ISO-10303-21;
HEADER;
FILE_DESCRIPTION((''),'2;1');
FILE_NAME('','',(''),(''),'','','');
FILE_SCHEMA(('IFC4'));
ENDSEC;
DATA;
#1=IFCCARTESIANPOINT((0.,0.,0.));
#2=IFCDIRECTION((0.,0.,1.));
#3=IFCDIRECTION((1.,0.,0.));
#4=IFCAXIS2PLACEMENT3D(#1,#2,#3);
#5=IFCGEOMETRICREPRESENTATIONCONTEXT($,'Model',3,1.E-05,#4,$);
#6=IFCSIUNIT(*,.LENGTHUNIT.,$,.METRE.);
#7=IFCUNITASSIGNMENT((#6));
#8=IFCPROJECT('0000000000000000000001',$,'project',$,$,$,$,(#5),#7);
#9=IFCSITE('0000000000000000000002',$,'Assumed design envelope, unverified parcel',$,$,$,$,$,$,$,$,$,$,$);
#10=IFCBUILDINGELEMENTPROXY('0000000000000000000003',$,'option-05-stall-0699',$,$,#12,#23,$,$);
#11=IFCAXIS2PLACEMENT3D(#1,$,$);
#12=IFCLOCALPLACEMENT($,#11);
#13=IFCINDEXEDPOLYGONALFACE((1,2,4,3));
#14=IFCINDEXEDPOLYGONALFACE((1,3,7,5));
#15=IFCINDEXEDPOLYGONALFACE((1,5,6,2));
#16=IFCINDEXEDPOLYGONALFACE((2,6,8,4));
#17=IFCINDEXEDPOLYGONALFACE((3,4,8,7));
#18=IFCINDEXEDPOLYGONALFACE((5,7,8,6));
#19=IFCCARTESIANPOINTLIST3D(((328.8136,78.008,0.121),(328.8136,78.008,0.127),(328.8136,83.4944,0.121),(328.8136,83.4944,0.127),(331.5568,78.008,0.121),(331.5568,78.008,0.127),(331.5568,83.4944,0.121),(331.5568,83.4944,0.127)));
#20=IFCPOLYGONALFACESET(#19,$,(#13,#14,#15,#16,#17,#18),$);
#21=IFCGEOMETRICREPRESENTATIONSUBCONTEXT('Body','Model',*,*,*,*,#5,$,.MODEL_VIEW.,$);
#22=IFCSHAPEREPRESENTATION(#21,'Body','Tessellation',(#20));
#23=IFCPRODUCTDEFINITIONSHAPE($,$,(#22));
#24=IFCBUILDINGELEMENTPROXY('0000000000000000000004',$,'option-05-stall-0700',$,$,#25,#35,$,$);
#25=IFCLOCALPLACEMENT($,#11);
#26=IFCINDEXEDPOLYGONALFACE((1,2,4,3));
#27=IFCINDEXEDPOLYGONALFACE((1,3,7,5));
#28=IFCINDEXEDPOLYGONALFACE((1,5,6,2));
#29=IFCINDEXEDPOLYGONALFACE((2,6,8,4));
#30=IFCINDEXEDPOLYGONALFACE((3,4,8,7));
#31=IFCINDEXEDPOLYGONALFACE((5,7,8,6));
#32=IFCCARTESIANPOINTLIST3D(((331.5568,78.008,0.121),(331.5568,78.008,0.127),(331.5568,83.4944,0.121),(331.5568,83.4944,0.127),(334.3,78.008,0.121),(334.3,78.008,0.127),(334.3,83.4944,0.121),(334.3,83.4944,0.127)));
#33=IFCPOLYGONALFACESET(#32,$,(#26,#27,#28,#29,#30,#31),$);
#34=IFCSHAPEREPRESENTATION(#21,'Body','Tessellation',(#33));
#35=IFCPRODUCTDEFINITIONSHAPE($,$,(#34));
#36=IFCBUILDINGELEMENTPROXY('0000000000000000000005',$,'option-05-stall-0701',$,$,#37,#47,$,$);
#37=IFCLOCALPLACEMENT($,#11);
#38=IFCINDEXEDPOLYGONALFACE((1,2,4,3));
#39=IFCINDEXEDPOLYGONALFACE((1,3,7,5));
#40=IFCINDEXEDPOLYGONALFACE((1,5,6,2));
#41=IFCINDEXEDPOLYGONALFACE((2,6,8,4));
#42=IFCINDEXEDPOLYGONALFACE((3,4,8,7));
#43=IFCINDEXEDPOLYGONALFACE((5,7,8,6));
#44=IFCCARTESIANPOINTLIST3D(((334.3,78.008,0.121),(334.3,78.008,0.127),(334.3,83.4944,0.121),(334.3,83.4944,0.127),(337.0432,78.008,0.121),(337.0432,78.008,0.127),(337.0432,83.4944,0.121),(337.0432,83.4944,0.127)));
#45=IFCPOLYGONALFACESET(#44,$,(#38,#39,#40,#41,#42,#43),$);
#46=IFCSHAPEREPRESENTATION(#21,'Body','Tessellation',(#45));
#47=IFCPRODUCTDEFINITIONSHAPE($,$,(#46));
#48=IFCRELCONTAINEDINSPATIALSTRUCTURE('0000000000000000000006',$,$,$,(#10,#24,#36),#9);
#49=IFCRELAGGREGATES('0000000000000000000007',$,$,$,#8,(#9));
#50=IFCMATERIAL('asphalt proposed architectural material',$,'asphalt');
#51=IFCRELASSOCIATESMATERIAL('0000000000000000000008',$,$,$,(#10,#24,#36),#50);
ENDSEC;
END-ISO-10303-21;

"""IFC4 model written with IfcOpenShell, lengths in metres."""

from ifc_helpers import new_model, si_unit, frame, origin_with_axes, place, context, subcontext, project, spatial, rectangle, extrude, material, element, save


model = new_model("IFC4")

# Units and contexts
model_context = context("Model", 3, precision=1e-05, world=origin_with_axes())
body_context = subcontext(model_context, "Body", "Model", "MODEL_VIEW")
ifc_project = project(units=[si_unit("LENGTHUNIT", "METRE")], contexts=[model_context])

# Site
site = spatial("IfcSite", under=ifc_project, Name="Assumed design envelope, unverified parcel")

# Building element proxies
ifc_material = material(Name="asphalt proposed architectural material", Category="asphalt")
for number, where, z_axis, x_axis, name in (
    (1, (330.1852, 80.7512, 0.121), (0.0, 0.0, 1.0), (1.0, 0.0, 0.0), "option-05-stall-0699"),
    (2, (332.9284, 80.7512, 0.121), (0.0, 0.0, 1.0), (1.0, 0.0, 0.0), "option-05-stall-0700"),
    (3, (335.6716, 80.7512, 0.121), (0.0, 0.0, 1.0), (1.0, 0.0, 0.0), "option-05-stall-0701"),
):
    element("IfcBuildingElementProxy", number, at=place(None, frame(where, z_axis=z_axis, x_axis=x_axis)), inside=site, material=ifc_material, Name=name, context=body_context, shape_type="SweptSolid", body=[
        extrude(rectangle(XDim=2.7432, YDim=5.4864), origin_with_axes(), (0.0, 0.0, 1.0), 0.006),
    ])

save(model, "model.ifc")
